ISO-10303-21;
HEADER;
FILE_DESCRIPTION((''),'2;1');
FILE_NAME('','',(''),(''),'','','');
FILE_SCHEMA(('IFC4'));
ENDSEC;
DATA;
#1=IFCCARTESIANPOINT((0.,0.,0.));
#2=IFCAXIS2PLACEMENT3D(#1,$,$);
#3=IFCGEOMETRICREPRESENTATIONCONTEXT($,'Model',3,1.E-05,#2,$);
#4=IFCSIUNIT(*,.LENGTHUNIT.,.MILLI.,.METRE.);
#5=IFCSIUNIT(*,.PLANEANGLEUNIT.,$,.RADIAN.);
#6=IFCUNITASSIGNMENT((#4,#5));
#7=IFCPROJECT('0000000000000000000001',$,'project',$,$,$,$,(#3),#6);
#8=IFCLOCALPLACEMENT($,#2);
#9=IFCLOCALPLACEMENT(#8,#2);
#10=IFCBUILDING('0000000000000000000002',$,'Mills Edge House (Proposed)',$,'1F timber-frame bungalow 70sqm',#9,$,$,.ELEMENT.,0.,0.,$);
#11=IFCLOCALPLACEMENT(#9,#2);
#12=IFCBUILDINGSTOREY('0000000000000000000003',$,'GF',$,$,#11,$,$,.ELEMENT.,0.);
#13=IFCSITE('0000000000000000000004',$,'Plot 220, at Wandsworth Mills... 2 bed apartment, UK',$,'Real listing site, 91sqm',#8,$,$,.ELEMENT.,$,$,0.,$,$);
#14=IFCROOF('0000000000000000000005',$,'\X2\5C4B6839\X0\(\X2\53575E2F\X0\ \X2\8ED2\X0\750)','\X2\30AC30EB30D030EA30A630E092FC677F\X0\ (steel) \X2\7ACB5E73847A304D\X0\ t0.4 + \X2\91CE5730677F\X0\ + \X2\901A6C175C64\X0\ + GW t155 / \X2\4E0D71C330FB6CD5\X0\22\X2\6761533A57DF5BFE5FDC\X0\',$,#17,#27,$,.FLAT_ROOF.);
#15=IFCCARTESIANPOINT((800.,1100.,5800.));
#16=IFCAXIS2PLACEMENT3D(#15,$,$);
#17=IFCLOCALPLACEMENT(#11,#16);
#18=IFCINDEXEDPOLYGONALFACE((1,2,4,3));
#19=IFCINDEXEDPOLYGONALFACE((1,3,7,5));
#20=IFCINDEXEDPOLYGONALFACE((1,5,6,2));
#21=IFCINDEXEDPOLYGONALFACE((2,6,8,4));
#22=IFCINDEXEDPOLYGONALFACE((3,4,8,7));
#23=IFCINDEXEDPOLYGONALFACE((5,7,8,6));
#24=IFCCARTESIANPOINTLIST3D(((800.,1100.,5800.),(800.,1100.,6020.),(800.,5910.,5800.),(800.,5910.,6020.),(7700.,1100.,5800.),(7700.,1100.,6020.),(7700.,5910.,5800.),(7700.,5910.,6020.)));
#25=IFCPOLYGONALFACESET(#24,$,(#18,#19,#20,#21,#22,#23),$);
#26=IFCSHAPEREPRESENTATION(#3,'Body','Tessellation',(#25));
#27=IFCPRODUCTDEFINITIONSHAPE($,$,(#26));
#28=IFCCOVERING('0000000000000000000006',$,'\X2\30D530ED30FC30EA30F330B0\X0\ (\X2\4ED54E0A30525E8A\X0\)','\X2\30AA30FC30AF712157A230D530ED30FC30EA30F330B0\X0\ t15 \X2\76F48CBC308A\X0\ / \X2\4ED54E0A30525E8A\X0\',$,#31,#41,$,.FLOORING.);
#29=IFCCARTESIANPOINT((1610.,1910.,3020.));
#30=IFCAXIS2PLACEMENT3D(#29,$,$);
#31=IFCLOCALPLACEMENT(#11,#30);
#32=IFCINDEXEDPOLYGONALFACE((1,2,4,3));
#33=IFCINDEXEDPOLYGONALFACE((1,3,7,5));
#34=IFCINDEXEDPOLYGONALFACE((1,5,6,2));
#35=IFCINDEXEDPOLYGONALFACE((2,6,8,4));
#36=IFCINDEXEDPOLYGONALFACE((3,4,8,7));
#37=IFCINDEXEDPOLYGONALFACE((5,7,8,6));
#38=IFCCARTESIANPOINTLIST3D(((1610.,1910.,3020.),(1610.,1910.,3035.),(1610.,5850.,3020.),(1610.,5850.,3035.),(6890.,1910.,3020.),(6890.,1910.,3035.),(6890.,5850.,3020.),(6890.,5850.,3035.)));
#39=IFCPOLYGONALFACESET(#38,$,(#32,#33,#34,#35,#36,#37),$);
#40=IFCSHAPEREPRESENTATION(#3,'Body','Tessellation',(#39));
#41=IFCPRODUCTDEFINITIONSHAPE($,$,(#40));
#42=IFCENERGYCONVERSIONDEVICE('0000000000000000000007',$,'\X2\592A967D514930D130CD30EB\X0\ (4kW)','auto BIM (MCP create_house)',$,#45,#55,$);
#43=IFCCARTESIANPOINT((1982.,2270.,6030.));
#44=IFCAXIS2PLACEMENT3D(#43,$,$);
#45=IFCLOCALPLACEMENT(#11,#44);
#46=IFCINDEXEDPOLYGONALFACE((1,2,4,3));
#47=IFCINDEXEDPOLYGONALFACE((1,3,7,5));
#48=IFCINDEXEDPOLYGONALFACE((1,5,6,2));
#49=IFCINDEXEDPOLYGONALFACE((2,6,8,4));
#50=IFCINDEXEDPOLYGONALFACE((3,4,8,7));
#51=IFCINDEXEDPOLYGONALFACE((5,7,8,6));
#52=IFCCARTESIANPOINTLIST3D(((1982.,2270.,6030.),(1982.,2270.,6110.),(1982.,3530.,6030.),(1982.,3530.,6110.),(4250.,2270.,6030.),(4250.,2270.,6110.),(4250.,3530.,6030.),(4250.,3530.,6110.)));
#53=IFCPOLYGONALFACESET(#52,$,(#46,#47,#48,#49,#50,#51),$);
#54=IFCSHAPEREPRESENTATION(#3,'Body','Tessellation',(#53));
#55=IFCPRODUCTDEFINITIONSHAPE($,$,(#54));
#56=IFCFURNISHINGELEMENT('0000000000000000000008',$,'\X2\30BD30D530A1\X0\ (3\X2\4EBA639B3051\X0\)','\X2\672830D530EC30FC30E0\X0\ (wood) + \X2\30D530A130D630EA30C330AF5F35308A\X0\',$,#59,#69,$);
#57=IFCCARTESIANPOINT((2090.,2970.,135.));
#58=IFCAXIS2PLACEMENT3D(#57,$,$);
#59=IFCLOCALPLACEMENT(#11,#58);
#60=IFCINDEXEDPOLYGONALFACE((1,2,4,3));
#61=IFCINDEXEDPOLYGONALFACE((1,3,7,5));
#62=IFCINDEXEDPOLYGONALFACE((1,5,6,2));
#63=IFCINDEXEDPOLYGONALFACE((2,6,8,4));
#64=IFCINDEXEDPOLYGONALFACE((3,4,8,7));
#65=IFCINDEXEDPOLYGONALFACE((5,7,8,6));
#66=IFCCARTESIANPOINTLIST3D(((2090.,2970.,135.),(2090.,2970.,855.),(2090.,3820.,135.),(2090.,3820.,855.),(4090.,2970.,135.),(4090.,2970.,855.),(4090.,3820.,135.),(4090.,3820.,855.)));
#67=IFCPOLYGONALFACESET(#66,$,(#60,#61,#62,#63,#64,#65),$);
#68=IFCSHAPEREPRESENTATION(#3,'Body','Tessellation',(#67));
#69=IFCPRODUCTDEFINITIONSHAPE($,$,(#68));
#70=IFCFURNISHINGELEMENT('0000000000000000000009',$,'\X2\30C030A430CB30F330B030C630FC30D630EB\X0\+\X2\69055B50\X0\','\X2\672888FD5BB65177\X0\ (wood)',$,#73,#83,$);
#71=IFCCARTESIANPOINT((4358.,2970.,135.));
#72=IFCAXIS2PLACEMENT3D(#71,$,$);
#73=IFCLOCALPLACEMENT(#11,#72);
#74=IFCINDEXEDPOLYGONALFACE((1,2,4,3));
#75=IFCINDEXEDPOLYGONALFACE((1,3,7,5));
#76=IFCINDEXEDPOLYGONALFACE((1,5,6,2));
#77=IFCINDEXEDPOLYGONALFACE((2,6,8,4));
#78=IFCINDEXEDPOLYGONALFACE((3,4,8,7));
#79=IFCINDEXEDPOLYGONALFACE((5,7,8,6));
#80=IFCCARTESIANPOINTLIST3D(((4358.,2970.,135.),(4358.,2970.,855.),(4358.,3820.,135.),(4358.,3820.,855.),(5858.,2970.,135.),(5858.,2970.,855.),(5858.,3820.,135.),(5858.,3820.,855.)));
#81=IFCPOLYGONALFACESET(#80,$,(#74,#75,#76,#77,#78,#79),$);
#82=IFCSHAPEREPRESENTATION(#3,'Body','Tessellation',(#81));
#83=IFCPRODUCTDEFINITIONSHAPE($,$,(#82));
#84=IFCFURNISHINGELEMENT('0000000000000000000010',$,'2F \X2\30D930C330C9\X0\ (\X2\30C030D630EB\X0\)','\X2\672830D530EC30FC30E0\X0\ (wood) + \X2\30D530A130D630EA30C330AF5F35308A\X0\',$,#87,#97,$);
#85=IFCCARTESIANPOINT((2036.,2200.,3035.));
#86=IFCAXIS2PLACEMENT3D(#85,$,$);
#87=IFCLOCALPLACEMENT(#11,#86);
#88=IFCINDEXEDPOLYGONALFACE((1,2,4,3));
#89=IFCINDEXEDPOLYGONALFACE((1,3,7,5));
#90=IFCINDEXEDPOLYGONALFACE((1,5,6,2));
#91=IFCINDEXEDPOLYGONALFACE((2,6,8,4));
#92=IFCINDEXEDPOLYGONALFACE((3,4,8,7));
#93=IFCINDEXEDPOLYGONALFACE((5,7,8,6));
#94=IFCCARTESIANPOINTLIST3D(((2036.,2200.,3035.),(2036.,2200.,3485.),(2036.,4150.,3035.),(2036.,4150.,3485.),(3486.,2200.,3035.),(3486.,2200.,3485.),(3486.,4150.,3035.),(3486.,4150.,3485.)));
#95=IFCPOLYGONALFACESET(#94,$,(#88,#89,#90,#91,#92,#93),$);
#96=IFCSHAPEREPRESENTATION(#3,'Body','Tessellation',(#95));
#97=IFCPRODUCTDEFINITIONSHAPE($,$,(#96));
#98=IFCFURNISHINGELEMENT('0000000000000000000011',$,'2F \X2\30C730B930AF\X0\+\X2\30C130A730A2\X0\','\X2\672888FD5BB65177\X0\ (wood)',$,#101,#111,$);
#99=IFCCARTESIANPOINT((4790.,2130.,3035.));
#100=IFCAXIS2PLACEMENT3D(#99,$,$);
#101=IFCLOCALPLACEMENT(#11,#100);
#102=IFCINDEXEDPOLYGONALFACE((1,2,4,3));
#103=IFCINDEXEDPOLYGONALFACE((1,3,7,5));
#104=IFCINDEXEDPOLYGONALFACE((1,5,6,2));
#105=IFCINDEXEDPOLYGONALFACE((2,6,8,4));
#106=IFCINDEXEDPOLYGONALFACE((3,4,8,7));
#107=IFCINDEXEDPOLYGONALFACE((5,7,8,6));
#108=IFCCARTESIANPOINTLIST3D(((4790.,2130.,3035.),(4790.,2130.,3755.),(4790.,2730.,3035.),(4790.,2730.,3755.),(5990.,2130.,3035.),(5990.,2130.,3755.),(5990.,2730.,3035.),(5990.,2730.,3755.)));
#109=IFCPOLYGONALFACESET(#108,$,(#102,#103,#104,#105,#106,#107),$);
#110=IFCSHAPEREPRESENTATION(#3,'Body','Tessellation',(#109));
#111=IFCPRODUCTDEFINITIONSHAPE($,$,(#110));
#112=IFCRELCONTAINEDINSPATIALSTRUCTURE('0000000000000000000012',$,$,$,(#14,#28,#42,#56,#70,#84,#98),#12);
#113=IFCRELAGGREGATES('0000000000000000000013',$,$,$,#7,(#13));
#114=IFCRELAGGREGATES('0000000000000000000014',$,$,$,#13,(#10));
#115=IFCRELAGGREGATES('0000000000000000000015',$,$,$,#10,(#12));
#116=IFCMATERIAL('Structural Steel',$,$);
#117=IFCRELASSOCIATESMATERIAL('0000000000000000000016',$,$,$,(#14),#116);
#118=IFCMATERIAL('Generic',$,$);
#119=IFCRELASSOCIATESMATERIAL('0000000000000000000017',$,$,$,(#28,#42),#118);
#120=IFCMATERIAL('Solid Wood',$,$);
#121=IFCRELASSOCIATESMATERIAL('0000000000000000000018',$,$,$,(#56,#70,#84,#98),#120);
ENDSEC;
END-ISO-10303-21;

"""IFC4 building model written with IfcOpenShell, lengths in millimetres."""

from ifc_helpers import new_model, si_unit, frame, frame_2d, origin, place, context, project, spatial, rectangle, extrude, material, element, save


model = new_model("IFC4")

# Units and contexts
model_context = context("Model", 3, precision=1e-05, world=origin())
ifc_project = project(units=[si_unit("LENGTHUNIT", "METRE", prefix="MILLI"), si_unit("PLANEANGLEUNIT", "RADIAN")], contexts=[model_context])

# Site, building, storey
site_placement = place(None, origin())
site = spatial("IfcSite", under=ifc_project, at=site_placement, Name="Plot 220, at Wandsworth Mills... 2 bed apartment, UK", ObjectType="Real listing site, 91sqm", CompositionType="ELEMENT", RefElevation=0.0)
building_placement = place(site_placement, origin())
building = spatial("IfcBuilding", under=site, at=building_placement, Name="Mills Edge House (Proposed)", ObjectType="1F timber-frame bungalow 70sqm", CompositionType="ELEMENT", ElevationOfRefHeight=0.0, ElevationOfTerrain=0.0)
storey_placement = place(building_placement, origin())
storey = spatial("IfcBuildingStorey", under=building, at=storey_placement, Name="GF", CompositionType="ELEMENT", Elevation=0.0)

# Shared definitions
ifc_material_1 = material(Name="Solid Wood")

# Shared definitions
ifc_material_2 = material(Name="Generic")

# Roof
ifc_material_3 = material(Name="Structural Steel")
for number, where, name in (
    (1, (800.0, 1100.0, 5800.0), "屋根(南帯 軒750)"),
):
    element("IfcRoof", number, at=place(storey_placement, frame(where)), inside=storey, material=ifc_material_3, Name=name, Description="ガルバリウム鋼板 (steel) 立平葺き t0.4 + 野地板 + 通気層 + GW t155 / 不燃・法22条区域対応", PredefinedType="FLAT_ROOF", context=model_context, shape_type="SweptSolid", body=[
        extrude(rectangle(XDim=6900.0, YDim=4810.0, at=frame_2d((3450.0, 2405.0))), frame((800.0, 1100.0, 5800.0)), (0.0, 0.0, 1.0), 220.0),
    ])

# Covering
covering_placement = place(storey_placement, frame((1610.0, 1910.0, 3020.0)))
element("IfcCovering", 2, at=covering_placement, inside=storey, material=ifc_material_2, Name="フローリング (仕上げ床)", Description="オーク無垢フローリング t15 直貼り / 仕上げ床", PredefinedType="FLOORING", context=model_context, shape_type="SweptSolid", body=[
    extrude(rectangle(XDim=5280.0, YDim=3940.0, at=frame_2d((2640.0, 1970.0))), frame((1610.0, 1910.0, 3020.0)), (0.0, 0.0, 1.0), 15.0),
])

# Energy conversion device
energy_conversion_device_placement = place(storey_placement, frame((1982.0, 2270.0, 6030.0)))
element("IfcEnergyConversionDevice", 3, at=energy_conversion_device_placement, inside=storey, material=ifc_material_2, Name="太陽光パネル (4kW)", Description="auto BIM (MCP create_house)", context=model_context, shape_type="SweptSolid", body=[
    extrude(rectangle(XDim=2268.0, YDim=1260.0, at=frame_2d((1134.0, 630.0))), frame((1982.0, 2270.0, 6030.0)), (0.0, 0.0, 1.0), 80.0),
])

# Furnishing elements
furnishing_1_placement = place(storey_placement, frame((2090.0, 2970.0, 135.0)))
element("IfcFurnishingElement", 4, at=furnishing_1_placement, inside=storey, material=ifc_material_1, Name="ソファ (3人掛け)", Description="木フレーム (wood) + ファブリック張り", context=model_context, shape_type="SweptSolid", body=[
    extrude(rectangle(XDim=2000.0, YDim=850.0, at=frame_2d((1000.0, 425.0))), frame((2090.0, 2970.0, 135.0)), (0.0, 0.0, 1.0), 720.0),
])
furnishing_2_placement = place(storey_placement, frame((4358.0, 2970.0, 135.0)))
element("IfcFurnishingElement", 5, at=furnishing_2_placement, inside=storey, material=ifc_material_1, Name="ダイニングテーブル+椅子", Description="木製家具 (wood)", context=model_context, shape_type="SweptSolid", body=[
    extrude(rectangle(XDim=1500.0, YDim=850.0, at=frame_2d((750.0, 425.0))), frame((4358.0, 2970.0, 135.0)), (0.0, 0.0, 1.0), 720.0),
])
furnishing_3_placement = place(storey_placement, frame((2036.0, 2200.0, 3035.0)))
element("IfcFurnishingElement", 6, at=furnishing_3_placement, inside=storey, material=ifc_material_1, Name="2F ベッド (ダブル)", Description="木フレーム (wood) + ファブリック張り", context=model_context, shape_type="SweptSolid", body=[
    extrude(rectangle(XDim=1450.0, YDim=1950.0, at=frame_2d((725.0, 975.0))), frame((2036.0, 2200.0, 3035.0)), (0.0, 0.0, 1.0), 450.0),
])
furnishing_4_placement = place(storey_placement, frame((4790.0, 2130.0, 3035.0)))
element("IfcFurnishingElement", 7, at=furnishing_4_placement, inside=storey, material=ifc_material_1, Name="2F デスク+チェア", Description="木製家具 (wood)", context=model_context, shape_type="SweptSolid", body=[
    extrude(rectangle(XDim=1200.0, YDim=600.0, at=frame_2d((600.0, 300.0))), frame((4790.0, 2130.0, 3035.0)), (0.0, 0.0, 1.0), 720.0),
])

save(model, "model.ifc")
